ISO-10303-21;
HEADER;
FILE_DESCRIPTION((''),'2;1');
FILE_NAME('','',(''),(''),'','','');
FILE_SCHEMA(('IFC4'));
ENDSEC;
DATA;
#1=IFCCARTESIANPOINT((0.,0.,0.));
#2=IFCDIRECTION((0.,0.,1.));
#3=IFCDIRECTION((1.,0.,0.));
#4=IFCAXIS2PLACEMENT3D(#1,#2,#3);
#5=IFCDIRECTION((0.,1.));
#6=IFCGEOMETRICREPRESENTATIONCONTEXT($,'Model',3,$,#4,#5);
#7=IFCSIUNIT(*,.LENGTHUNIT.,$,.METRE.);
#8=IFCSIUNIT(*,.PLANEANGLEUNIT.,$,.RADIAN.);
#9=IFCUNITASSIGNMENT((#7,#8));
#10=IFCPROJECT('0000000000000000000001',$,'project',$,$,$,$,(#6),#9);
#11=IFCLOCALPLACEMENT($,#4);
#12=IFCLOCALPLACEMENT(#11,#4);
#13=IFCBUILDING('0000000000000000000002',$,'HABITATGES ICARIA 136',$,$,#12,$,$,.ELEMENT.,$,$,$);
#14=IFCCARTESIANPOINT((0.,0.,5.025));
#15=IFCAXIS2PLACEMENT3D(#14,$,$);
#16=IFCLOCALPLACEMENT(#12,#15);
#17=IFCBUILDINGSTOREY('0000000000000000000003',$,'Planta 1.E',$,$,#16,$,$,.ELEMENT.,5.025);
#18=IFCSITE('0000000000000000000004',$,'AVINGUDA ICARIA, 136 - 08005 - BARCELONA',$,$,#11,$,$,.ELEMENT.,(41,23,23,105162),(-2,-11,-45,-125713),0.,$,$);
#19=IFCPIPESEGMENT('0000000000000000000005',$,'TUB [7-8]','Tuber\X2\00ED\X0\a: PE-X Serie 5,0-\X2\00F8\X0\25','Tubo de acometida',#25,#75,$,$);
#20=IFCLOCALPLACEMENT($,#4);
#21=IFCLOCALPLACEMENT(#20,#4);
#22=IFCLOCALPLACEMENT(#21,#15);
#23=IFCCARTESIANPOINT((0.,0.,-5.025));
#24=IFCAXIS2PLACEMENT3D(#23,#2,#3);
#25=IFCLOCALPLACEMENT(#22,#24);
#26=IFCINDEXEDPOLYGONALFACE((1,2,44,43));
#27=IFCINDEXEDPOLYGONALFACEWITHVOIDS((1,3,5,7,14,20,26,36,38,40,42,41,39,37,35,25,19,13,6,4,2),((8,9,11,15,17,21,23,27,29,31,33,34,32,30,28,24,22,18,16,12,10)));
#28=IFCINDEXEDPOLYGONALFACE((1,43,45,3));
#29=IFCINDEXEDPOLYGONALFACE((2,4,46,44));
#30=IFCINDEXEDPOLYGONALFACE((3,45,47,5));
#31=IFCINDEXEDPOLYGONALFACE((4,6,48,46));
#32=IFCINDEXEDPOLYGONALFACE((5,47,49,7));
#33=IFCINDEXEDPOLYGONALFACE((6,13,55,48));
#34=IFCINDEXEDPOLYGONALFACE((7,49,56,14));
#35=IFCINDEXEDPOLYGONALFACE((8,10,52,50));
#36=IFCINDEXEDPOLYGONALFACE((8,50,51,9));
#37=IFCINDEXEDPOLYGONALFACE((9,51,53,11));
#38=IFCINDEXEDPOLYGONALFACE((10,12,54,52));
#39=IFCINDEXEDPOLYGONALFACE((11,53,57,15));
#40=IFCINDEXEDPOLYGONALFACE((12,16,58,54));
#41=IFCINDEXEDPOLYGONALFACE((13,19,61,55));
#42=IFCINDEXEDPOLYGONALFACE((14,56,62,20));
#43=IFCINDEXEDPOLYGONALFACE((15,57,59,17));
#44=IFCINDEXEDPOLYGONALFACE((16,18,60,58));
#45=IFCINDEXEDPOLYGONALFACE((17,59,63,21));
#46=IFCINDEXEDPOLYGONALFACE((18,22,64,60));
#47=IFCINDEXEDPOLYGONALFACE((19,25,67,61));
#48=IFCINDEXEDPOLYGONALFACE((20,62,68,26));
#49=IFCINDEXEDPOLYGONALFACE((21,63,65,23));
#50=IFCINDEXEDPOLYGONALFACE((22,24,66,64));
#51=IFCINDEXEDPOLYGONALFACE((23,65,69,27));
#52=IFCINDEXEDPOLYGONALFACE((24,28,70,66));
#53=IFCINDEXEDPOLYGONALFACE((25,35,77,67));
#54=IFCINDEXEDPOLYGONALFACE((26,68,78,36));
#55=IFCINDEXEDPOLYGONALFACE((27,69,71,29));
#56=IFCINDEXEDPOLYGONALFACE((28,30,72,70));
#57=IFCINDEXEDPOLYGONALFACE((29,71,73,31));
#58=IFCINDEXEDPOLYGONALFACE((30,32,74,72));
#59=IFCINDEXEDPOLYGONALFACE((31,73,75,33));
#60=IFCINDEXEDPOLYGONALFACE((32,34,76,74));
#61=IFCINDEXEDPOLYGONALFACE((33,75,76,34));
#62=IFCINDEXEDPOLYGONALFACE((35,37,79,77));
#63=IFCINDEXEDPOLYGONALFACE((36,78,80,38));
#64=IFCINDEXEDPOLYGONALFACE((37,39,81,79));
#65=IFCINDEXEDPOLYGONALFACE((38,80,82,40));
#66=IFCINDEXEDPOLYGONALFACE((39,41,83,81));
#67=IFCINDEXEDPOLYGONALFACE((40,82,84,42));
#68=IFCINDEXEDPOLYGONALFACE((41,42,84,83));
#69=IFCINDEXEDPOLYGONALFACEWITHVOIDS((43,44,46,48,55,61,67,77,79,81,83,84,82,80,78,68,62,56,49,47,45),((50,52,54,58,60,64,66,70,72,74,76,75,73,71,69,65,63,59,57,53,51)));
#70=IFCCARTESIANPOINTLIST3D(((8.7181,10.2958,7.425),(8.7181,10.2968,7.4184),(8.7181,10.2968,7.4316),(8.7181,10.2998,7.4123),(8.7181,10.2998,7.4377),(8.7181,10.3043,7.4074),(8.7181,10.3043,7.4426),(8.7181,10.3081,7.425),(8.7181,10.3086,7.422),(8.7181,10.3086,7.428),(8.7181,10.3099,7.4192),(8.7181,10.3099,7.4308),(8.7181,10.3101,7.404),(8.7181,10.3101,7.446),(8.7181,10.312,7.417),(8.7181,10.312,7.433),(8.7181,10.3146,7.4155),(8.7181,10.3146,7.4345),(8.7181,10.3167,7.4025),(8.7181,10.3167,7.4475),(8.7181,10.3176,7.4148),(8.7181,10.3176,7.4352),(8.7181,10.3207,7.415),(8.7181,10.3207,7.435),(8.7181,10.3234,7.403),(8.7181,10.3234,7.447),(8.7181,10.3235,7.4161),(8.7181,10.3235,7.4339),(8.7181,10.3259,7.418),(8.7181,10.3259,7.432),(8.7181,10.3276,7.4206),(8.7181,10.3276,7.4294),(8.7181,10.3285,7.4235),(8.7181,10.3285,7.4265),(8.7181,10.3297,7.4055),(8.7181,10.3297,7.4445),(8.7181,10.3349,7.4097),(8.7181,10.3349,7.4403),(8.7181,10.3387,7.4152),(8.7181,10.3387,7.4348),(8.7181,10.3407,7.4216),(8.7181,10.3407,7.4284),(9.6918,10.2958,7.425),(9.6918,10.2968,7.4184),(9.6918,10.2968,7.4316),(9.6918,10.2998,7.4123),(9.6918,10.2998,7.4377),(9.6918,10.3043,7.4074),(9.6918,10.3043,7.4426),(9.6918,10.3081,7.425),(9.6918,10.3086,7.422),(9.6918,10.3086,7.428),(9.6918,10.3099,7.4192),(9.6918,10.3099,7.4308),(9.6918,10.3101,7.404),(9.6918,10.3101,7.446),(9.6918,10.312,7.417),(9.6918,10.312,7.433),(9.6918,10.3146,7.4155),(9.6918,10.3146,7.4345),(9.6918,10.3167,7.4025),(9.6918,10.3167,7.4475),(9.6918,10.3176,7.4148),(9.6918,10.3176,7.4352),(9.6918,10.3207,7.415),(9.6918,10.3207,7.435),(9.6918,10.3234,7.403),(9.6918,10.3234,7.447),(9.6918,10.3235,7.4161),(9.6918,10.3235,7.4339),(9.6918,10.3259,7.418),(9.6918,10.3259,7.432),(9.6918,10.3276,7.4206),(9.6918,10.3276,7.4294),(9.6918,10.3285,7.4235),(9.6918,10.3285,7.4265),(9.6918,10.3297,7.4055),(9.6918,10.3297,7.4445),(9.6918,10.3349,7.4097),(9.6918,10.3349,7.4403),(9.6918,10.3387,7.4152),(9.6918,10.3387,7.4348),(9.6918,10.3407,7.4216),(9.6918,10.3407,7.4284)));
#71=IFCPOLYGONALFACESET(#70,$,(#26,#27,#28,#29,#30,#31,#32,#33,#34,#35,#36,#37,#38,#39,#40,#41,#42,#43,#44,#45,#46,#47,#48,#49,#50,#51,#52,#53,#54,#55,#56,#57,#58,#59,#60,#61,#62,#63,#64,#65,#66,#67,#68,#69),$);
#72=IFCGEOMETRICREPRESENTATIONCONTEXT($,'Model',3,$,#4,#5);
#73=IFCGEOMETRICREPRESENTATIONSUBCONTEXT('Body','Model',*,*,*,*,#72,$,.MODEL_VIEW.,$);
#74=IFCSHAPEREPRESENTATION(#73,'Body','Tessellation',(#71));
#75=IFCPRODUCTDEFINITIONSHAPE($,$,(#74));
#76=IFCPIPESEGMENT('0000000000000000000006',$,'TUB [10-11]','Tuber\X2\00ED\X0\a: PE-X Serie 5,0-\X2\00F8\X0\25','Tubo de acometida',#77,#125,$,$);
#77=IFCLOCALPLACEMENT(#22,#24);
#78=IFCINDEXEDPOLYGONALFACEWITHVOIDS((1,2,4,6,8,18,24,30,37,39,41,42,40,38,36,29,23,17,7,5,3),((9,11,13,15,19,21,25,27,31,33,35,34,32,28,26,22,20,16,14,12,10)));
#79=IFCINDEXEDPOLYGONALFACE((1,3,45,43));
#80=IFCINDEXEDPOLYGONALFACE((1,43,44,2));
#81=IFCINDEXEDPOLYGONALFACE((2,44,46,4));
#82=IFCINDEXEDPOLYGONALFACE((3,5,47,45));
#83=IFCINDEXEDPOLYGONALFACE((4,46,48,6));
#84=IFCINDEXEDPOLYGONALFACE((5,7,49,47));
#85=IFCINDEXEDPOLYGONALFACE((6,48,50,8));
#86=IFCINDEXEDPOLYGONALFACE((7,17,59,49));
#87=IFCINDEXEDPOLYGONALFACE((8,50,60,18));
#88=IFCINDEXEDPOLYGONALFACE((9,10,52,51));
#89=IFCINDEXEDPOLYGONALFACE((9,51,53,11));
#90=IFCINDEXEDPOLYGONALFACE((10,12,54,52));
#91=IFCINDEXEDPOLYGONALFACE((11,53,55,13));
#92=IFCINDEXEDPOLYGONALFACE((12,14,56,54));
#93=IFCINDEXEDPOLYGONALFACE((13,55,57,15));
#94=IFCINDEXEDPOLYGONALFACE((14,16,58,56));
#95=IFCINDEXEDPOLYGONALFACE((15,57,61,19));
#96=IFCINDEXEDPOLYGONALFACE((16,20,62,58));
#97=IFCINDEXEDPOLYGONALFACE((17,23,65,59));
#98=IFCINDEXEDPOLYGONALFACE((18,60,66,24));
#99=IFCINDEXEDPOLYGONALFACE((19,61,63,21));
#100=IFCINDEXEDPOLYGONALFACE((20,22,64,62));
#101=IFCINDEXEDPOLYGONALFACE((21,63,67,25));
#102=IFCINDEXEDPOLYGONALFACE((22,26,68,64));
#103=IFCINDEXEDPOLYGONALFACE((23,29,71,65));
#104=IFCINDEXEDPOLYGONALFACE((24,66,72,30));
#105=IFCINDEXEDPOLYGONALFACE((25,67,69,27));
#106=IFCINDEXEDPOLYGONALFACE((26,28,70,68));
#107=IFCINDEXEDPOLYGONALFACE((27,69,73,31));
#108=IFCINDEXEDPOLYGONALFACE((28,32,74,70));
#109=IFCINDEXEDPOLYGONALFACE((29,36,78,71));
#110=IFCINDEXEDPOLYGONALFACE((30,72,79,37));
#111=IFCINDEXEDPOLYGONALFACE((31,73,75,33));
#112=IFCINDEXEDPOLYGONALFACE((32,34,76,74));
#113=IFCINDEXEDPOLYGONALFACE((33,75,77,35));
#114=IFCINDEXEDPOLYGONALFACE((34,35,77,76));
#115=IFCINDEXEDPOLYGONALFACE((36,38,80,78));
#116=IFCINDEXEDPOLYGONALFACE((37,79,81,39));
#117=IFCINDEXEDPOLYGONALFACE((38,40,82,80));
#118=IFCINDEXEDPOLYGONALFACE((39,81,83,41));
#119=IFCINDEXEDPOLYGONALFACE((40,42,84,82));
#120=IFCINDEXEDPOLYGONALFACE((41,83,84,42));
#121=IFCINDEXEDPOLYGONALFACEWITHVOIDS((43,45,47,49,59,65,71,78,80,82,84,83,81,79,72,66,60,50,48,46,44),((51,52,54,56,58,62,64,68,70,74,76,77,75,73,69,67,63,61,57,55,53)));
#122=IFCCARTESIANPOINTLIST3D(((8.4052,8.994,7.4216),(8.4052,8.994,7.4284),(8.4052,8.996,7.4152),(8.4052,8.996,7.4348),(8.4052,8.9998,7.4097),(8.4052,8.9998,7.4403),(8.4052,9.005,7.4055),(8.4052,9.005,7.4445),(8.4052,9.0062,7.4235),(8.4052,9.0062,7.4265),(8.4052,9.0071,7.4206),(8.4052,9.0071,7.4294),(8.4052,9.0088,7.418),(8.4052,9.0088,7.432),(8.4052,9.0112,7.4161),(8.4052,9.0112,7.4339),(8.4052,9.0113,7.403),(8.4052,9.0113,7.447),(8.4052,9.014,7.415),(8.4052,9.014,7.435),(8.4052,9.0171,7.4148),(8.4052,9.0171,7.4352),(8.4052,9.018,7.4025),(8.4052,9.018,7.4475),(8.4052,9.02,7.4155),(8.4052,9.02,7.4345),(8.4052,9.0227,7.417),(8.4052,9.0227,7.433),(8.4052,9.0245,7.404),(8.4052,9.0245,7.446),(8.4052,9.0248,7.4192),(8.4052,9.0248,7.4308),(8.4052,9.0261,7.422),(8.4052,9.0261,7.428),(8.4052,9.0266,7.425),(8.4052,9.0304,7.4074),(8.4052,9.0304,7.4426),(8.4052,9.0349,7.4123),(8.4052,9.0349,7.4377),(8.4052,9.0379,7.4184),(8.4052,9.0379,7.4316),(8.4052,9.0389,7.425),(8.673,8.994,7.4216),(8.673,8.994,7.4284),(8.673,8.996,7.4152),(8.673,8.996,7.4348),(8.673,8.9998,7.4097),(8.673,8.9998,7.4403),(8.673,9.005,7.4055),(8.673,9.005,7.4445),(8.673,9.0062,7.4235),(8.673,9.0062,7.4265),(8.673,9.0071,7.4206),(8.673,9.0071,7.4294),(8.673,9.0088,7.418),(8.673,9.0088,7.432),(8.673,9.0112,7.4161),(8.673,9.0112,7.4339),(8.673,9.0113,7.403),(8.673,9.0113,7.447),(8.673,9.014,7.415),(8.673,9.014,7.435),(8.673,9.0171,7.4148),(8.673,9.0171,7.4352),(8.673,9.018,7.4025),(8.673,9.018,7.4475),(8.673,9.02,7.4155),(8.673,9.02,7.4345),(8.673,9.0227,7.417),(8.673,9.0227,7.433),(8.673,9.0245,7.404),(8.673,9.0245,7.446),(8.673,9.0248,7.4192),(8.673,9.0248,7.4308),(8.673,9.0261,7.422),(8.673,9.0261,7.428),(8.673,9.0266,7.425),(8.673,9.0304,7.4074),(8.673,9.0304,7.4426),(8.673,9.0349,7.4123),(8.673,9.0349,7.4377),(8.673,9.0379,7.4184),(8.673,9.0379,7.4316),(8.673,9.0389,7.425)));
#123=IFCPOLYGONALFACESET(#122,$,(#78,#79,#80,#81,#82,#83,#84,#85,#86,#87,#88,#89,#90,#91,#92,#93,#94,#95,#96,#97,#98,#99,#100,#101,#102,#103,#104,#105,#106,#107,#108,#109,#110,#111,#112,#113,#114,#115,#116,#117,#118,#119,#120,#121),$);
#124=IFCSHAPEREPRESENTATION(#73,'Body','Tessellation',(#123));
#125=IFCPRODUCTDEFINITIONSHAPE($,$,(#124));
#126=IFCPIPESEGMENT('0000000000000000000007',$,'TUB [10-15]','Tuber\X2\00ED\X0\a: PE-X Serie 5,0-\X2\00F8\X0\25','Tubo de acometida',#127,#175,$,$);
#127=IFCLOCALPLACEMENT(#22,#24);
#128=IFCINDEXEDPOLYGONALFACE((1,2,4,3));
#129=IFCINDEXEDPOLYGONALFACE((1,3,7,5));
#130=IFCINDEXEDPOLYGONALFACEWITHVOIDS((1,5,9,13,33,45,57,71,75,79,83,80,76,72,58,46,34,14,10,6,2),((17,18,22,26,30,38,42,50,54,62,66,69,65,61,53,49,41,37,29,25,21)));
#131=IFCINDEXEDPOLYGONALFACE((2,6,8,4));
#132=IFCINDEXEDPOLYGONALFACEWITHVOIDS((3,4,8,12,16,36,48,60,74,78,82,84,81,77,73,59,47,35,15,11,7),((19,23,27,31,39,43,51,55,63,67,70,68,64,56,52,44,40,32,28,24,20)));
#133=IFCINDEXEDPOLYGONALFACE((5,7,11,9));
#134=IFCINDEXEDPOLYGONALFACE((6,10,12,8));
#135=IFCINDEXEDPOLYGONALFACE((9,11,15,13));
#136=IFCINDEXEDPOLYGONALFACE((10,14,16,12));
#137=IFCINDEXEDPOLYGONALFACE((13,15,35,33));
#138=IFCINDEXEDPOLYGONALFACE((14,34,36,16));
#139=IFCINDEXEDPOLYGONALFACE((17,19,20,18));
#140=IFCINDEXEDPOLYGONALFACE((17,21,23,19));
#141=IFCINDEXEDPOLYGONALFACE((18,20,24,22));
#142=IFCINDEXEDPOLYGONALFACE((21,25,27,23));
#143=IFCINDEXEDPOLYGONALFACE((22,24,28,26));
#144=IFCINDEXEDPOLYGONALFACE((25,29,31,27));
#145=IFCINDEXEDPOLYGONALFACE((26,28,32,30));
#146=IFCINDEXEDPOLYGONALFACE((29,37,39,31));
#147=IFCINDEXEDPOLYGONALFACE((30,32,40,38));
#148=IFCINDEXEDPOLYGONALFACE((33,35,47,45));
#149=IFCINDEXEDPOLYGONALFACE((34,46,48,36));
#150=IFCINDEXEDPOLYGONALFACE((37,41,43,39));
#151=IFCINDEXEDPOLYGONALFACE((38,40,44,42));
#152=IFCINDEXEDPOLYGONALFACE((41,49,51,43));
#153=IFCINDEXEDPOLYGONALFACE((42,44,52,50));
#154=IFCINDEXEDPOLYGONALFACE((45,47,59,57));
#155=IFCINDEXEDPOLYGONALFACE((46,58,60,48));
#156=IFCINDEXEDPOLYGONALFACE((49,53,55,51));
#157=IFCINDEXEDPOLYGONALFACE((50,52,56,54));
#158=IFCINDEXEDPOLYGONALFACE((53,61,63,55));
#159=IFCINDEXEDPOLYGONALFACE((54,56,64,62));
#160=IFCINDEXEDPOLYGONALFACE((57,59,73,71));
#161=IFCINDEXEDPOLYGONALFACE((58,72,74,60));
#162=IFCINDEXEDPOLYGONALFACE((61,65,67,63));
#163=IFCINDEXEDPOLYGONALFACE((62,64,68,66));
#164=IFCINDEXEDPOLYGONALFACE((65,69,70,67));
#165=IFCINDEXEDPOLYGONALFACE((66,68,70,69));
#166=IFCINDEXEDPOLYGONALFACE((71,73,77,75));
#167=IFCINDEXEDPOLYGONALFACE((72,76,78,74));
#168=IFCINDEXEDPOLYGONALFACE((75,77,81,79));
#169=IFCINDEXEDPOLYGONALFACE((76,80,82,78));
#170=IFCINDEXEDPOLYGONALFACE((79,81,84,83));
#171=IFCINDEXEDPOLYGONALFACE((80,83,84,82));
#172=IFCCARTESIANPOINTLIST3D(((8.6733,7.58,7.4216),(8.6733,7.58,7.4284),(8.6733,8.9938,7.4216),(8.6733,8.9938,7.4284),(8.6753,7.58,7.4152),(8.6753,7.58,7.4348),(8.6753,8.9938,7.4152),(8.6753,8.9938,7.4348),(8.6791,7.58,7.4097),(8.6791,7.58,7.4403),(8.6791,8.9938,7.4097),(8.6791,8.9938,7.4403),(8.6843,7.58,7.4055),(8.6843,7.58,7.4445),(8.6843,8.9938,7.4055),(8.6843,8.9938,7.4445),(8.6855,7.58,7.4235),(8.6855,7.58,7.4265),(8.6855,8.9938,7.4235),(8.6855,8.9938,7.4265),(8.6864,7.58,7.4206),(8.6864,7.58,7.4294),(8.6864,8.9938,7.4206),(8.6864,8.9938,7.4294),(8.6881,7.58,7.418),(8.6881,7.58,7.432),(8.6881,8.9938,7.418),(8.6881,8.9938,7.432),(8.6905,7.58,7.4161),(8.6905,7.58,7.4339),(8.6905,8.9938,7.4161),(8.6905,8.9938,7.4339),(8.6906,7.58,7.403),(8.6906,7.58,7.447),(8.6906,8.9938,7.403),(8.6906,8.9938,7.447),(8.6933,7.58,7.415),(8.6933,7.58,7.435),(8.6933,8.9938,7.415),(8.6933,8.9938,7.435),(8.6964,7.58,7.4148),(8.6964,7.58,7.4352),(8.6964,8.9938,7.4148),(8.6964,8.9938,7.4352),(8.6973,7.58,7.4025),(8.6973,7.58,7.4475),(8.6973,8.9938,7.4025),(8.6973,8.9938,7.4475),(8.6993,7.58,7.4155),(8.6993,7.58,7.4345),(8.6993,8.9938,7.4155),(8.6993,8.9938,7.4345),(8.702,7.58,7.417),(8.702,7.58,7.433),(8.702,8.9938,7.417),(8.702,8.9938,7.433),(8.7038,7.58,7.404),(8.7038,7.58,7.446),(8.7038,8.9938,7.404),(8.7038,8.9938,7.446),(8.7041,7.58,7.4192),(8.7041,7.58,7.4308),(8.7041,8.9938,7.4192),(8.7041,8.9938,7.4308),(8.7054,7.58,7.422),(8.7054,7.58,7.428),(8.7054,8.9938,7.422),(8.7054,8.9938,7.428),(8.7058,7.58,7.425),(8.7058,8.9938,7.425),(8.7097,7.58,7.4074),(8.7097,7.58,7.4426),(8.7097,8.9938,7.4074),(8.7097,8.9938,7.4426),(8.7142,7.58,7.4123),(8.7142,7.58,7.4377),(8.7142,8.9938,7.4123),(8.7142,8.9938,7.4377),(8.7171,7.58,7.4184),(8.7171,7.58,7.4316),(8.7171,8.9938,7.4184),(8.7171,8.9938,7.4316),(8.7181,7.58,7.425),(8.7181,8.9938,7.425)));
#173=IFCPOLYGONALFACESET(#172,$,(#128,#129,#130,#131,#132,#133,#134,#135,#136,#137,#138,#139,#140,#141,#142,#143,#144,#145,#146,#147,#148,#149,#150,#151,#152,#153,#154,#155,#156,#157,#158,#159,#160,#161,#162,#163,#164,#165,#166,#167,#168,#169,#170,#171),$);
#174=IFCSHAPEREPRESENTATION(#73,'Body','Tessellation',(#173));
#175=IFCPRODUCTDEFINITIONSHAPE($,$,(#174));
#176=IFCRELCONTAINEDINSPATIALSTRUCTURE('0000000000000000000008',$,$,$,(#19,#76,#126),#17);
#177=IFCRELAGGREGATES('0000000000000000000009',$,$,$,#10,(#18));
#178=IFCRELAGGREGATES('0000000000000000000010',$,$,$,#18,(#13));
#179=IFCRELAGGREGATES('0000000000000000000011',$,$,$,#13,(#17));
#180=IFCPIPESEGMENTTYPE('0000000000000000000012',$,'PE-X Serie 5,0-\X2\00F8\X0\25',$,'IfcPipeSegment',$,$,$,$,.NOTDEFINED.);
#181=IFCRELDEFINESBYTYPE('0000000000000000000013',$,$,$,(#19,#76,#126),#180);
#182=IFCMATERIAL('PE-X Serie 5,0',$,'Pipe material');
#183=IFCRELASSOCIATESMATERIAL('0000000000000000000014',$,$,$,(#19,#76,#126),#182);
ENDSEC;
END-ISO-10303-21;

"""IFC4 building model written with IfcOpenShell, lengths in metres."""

from ifc_helpers import new_model, si_unit, direction, frame, origin_with_axes, origin_2d_with_axis, place, context, subcontext, project, spatial, hollow_circle, extrude, material, type_object, element, save


model = new_model("IFC4")

# Units and contexts
model_context_1 = context("Model", 3, world=origin_with_axes(), true_north=direction((0.0, 1.0)))
model_context_2 = context("Model", 3, world=origin_with_axes(), true_north=direction((0.0, 1.0)))
body_context_1 = subcontext(model_context_2, "Body", "Model", "MODEL_VIEW")
ifc_project = project(units=[si_unit("LENGTHUNIT", "METRE"), si_unit("PLANEANGLEUNIT", "RADIAN")], contexts=[model_context_1])

# Site, building, storey
site_placement = place(None, origin_with_axes())
site = spatial("IfcSite", under=ifc_project, at=site_placement, Name="AVINGUDA ICARIA, 136 - 08005 - BARCELONA", CompositionType="ELEMENT", RefLatitude=(41, 23, 23, 105162), RefLongitude=(-2, -11, -45, -125713), RefElevation=0.0)
building_placement = place(site_placement, origin_with_axes())
building = spatial("IfcBuilding", under=site, at=building_placement, Name="HABITATGES ICARIA 136", CompositionType="ELEMENT")
storey_placement = place(building_placement, frame((0.0, 0.0, 5.025)))
storey = spatial("IfcBuildingStorey", under=building, at=storey_placement, Name="Planta 1.E", CompositionType="ELEMENT", Elevation=5.025)

# Shared definitions
ifc_material_1 = material(Name="PE-X Serie 5,0", Category="Pipe material")
placement_1 = place(None, origin_with_axes())
placement_2 = place(placement_1, origin_with_axes())
placement_3 = place(placement_2, frame((0.0, 0.0, 5.025)))

# Pipe segments
pipe_segment_type_1 = type_object("IfcPipeSegmentType", Name="PE-X Serie 5,0-ø25", ApplicableOccurrence="IfcPipeSegment", PredefinedType="NOTDEFINED")
pipe_segment_1_placement = place(placement_3, frame((0.0, 0.0, -5.025), z_axis=(0.0, 0.0, 1.0), x_axis=(1.0, 0.0, 0.0)))
element("IfcPipeSegment", 1, at=pipe_segment_1_placement, inside=storey, type_object=pipe_segment_type_1, material=ifc_material_1, Name="TUB [7-8]", Description="Tubería: PE-X Serie 5,0-ø25", ObjectType="Tubo de acometida", context=body_context_1, shape_type="SweptSolid", body=[
    extrude(hollow_circle(Radius=0.0226, WallThickness=0.0123, at=origin_2d_with_axis()), frame((9.6918, 10.3184, 7.425), z_axis=(-1.0, 0.0, 0.0), x_axis=(0.0, -1.0, 0.0)), (0.0, 0.0, 1.0), 0.9736),
])
pipe_segment_2_placement = place(placement_3, frame((0.0, 0.0, -5.025), z_axis=(0.0, 0.0, 1.0), x_axis=(1.0, 0.0, 0.0)))
element("IfcPipeSegment", 2, at=pipe_segment_2_placement, inside=storey, type_object=pipe_segment_type_1, material=ifc_material_1, Name="TUB [10-11]", Description="Tubería: PE-X Serie 5,0-ø25", ObjectType="Tubo de acometida", context=body_context_1, shape_type="SweptSolid", body=[
    extrude(hollow_circle(Radius=0.0226, WallThickness=0.0123, at=origin_2d_with_axis()), frame((8.4052, 9.0163, 7.425), z_axis=(1.0, 0.0, 0.0), x_axis=(0.0, 1.0, 0.0)), (0.0, 0.0, 1.0), 0.2679),
])
pipe_segment_3_placement = place(placement_3, frame((0.0, 0.0, -5.025), z_axis=(0.0, 0.0, 1.0), x_axis=(1.0, 0.0, 0.0)))
element("IfcPipeSegment", 3, at=pipe_segment_3_placement, inside=storey, type_object=pipe_segment_type_1, material=ifc_material_1, Name="TUB [10-15]", Description="Tubería: PE-X Serie 5,0-ø25", ObjectType="Tubo de acometida", context=body_context_1, shape_type="SweptSolid", body=[
    extrude(hollow_circle(Radius=0.0226, WallThickness=0.0123, at=origin_2d_with_axis()), frame((8.6956, 8.9938, 7.425), z_axis=(0.0, -1.0, 0.0), x_axis=(1.0, 0.0, 0.0)), (0.0, 0.0, 1.0), 1.4137),
])

save(model, "model.ifc")
